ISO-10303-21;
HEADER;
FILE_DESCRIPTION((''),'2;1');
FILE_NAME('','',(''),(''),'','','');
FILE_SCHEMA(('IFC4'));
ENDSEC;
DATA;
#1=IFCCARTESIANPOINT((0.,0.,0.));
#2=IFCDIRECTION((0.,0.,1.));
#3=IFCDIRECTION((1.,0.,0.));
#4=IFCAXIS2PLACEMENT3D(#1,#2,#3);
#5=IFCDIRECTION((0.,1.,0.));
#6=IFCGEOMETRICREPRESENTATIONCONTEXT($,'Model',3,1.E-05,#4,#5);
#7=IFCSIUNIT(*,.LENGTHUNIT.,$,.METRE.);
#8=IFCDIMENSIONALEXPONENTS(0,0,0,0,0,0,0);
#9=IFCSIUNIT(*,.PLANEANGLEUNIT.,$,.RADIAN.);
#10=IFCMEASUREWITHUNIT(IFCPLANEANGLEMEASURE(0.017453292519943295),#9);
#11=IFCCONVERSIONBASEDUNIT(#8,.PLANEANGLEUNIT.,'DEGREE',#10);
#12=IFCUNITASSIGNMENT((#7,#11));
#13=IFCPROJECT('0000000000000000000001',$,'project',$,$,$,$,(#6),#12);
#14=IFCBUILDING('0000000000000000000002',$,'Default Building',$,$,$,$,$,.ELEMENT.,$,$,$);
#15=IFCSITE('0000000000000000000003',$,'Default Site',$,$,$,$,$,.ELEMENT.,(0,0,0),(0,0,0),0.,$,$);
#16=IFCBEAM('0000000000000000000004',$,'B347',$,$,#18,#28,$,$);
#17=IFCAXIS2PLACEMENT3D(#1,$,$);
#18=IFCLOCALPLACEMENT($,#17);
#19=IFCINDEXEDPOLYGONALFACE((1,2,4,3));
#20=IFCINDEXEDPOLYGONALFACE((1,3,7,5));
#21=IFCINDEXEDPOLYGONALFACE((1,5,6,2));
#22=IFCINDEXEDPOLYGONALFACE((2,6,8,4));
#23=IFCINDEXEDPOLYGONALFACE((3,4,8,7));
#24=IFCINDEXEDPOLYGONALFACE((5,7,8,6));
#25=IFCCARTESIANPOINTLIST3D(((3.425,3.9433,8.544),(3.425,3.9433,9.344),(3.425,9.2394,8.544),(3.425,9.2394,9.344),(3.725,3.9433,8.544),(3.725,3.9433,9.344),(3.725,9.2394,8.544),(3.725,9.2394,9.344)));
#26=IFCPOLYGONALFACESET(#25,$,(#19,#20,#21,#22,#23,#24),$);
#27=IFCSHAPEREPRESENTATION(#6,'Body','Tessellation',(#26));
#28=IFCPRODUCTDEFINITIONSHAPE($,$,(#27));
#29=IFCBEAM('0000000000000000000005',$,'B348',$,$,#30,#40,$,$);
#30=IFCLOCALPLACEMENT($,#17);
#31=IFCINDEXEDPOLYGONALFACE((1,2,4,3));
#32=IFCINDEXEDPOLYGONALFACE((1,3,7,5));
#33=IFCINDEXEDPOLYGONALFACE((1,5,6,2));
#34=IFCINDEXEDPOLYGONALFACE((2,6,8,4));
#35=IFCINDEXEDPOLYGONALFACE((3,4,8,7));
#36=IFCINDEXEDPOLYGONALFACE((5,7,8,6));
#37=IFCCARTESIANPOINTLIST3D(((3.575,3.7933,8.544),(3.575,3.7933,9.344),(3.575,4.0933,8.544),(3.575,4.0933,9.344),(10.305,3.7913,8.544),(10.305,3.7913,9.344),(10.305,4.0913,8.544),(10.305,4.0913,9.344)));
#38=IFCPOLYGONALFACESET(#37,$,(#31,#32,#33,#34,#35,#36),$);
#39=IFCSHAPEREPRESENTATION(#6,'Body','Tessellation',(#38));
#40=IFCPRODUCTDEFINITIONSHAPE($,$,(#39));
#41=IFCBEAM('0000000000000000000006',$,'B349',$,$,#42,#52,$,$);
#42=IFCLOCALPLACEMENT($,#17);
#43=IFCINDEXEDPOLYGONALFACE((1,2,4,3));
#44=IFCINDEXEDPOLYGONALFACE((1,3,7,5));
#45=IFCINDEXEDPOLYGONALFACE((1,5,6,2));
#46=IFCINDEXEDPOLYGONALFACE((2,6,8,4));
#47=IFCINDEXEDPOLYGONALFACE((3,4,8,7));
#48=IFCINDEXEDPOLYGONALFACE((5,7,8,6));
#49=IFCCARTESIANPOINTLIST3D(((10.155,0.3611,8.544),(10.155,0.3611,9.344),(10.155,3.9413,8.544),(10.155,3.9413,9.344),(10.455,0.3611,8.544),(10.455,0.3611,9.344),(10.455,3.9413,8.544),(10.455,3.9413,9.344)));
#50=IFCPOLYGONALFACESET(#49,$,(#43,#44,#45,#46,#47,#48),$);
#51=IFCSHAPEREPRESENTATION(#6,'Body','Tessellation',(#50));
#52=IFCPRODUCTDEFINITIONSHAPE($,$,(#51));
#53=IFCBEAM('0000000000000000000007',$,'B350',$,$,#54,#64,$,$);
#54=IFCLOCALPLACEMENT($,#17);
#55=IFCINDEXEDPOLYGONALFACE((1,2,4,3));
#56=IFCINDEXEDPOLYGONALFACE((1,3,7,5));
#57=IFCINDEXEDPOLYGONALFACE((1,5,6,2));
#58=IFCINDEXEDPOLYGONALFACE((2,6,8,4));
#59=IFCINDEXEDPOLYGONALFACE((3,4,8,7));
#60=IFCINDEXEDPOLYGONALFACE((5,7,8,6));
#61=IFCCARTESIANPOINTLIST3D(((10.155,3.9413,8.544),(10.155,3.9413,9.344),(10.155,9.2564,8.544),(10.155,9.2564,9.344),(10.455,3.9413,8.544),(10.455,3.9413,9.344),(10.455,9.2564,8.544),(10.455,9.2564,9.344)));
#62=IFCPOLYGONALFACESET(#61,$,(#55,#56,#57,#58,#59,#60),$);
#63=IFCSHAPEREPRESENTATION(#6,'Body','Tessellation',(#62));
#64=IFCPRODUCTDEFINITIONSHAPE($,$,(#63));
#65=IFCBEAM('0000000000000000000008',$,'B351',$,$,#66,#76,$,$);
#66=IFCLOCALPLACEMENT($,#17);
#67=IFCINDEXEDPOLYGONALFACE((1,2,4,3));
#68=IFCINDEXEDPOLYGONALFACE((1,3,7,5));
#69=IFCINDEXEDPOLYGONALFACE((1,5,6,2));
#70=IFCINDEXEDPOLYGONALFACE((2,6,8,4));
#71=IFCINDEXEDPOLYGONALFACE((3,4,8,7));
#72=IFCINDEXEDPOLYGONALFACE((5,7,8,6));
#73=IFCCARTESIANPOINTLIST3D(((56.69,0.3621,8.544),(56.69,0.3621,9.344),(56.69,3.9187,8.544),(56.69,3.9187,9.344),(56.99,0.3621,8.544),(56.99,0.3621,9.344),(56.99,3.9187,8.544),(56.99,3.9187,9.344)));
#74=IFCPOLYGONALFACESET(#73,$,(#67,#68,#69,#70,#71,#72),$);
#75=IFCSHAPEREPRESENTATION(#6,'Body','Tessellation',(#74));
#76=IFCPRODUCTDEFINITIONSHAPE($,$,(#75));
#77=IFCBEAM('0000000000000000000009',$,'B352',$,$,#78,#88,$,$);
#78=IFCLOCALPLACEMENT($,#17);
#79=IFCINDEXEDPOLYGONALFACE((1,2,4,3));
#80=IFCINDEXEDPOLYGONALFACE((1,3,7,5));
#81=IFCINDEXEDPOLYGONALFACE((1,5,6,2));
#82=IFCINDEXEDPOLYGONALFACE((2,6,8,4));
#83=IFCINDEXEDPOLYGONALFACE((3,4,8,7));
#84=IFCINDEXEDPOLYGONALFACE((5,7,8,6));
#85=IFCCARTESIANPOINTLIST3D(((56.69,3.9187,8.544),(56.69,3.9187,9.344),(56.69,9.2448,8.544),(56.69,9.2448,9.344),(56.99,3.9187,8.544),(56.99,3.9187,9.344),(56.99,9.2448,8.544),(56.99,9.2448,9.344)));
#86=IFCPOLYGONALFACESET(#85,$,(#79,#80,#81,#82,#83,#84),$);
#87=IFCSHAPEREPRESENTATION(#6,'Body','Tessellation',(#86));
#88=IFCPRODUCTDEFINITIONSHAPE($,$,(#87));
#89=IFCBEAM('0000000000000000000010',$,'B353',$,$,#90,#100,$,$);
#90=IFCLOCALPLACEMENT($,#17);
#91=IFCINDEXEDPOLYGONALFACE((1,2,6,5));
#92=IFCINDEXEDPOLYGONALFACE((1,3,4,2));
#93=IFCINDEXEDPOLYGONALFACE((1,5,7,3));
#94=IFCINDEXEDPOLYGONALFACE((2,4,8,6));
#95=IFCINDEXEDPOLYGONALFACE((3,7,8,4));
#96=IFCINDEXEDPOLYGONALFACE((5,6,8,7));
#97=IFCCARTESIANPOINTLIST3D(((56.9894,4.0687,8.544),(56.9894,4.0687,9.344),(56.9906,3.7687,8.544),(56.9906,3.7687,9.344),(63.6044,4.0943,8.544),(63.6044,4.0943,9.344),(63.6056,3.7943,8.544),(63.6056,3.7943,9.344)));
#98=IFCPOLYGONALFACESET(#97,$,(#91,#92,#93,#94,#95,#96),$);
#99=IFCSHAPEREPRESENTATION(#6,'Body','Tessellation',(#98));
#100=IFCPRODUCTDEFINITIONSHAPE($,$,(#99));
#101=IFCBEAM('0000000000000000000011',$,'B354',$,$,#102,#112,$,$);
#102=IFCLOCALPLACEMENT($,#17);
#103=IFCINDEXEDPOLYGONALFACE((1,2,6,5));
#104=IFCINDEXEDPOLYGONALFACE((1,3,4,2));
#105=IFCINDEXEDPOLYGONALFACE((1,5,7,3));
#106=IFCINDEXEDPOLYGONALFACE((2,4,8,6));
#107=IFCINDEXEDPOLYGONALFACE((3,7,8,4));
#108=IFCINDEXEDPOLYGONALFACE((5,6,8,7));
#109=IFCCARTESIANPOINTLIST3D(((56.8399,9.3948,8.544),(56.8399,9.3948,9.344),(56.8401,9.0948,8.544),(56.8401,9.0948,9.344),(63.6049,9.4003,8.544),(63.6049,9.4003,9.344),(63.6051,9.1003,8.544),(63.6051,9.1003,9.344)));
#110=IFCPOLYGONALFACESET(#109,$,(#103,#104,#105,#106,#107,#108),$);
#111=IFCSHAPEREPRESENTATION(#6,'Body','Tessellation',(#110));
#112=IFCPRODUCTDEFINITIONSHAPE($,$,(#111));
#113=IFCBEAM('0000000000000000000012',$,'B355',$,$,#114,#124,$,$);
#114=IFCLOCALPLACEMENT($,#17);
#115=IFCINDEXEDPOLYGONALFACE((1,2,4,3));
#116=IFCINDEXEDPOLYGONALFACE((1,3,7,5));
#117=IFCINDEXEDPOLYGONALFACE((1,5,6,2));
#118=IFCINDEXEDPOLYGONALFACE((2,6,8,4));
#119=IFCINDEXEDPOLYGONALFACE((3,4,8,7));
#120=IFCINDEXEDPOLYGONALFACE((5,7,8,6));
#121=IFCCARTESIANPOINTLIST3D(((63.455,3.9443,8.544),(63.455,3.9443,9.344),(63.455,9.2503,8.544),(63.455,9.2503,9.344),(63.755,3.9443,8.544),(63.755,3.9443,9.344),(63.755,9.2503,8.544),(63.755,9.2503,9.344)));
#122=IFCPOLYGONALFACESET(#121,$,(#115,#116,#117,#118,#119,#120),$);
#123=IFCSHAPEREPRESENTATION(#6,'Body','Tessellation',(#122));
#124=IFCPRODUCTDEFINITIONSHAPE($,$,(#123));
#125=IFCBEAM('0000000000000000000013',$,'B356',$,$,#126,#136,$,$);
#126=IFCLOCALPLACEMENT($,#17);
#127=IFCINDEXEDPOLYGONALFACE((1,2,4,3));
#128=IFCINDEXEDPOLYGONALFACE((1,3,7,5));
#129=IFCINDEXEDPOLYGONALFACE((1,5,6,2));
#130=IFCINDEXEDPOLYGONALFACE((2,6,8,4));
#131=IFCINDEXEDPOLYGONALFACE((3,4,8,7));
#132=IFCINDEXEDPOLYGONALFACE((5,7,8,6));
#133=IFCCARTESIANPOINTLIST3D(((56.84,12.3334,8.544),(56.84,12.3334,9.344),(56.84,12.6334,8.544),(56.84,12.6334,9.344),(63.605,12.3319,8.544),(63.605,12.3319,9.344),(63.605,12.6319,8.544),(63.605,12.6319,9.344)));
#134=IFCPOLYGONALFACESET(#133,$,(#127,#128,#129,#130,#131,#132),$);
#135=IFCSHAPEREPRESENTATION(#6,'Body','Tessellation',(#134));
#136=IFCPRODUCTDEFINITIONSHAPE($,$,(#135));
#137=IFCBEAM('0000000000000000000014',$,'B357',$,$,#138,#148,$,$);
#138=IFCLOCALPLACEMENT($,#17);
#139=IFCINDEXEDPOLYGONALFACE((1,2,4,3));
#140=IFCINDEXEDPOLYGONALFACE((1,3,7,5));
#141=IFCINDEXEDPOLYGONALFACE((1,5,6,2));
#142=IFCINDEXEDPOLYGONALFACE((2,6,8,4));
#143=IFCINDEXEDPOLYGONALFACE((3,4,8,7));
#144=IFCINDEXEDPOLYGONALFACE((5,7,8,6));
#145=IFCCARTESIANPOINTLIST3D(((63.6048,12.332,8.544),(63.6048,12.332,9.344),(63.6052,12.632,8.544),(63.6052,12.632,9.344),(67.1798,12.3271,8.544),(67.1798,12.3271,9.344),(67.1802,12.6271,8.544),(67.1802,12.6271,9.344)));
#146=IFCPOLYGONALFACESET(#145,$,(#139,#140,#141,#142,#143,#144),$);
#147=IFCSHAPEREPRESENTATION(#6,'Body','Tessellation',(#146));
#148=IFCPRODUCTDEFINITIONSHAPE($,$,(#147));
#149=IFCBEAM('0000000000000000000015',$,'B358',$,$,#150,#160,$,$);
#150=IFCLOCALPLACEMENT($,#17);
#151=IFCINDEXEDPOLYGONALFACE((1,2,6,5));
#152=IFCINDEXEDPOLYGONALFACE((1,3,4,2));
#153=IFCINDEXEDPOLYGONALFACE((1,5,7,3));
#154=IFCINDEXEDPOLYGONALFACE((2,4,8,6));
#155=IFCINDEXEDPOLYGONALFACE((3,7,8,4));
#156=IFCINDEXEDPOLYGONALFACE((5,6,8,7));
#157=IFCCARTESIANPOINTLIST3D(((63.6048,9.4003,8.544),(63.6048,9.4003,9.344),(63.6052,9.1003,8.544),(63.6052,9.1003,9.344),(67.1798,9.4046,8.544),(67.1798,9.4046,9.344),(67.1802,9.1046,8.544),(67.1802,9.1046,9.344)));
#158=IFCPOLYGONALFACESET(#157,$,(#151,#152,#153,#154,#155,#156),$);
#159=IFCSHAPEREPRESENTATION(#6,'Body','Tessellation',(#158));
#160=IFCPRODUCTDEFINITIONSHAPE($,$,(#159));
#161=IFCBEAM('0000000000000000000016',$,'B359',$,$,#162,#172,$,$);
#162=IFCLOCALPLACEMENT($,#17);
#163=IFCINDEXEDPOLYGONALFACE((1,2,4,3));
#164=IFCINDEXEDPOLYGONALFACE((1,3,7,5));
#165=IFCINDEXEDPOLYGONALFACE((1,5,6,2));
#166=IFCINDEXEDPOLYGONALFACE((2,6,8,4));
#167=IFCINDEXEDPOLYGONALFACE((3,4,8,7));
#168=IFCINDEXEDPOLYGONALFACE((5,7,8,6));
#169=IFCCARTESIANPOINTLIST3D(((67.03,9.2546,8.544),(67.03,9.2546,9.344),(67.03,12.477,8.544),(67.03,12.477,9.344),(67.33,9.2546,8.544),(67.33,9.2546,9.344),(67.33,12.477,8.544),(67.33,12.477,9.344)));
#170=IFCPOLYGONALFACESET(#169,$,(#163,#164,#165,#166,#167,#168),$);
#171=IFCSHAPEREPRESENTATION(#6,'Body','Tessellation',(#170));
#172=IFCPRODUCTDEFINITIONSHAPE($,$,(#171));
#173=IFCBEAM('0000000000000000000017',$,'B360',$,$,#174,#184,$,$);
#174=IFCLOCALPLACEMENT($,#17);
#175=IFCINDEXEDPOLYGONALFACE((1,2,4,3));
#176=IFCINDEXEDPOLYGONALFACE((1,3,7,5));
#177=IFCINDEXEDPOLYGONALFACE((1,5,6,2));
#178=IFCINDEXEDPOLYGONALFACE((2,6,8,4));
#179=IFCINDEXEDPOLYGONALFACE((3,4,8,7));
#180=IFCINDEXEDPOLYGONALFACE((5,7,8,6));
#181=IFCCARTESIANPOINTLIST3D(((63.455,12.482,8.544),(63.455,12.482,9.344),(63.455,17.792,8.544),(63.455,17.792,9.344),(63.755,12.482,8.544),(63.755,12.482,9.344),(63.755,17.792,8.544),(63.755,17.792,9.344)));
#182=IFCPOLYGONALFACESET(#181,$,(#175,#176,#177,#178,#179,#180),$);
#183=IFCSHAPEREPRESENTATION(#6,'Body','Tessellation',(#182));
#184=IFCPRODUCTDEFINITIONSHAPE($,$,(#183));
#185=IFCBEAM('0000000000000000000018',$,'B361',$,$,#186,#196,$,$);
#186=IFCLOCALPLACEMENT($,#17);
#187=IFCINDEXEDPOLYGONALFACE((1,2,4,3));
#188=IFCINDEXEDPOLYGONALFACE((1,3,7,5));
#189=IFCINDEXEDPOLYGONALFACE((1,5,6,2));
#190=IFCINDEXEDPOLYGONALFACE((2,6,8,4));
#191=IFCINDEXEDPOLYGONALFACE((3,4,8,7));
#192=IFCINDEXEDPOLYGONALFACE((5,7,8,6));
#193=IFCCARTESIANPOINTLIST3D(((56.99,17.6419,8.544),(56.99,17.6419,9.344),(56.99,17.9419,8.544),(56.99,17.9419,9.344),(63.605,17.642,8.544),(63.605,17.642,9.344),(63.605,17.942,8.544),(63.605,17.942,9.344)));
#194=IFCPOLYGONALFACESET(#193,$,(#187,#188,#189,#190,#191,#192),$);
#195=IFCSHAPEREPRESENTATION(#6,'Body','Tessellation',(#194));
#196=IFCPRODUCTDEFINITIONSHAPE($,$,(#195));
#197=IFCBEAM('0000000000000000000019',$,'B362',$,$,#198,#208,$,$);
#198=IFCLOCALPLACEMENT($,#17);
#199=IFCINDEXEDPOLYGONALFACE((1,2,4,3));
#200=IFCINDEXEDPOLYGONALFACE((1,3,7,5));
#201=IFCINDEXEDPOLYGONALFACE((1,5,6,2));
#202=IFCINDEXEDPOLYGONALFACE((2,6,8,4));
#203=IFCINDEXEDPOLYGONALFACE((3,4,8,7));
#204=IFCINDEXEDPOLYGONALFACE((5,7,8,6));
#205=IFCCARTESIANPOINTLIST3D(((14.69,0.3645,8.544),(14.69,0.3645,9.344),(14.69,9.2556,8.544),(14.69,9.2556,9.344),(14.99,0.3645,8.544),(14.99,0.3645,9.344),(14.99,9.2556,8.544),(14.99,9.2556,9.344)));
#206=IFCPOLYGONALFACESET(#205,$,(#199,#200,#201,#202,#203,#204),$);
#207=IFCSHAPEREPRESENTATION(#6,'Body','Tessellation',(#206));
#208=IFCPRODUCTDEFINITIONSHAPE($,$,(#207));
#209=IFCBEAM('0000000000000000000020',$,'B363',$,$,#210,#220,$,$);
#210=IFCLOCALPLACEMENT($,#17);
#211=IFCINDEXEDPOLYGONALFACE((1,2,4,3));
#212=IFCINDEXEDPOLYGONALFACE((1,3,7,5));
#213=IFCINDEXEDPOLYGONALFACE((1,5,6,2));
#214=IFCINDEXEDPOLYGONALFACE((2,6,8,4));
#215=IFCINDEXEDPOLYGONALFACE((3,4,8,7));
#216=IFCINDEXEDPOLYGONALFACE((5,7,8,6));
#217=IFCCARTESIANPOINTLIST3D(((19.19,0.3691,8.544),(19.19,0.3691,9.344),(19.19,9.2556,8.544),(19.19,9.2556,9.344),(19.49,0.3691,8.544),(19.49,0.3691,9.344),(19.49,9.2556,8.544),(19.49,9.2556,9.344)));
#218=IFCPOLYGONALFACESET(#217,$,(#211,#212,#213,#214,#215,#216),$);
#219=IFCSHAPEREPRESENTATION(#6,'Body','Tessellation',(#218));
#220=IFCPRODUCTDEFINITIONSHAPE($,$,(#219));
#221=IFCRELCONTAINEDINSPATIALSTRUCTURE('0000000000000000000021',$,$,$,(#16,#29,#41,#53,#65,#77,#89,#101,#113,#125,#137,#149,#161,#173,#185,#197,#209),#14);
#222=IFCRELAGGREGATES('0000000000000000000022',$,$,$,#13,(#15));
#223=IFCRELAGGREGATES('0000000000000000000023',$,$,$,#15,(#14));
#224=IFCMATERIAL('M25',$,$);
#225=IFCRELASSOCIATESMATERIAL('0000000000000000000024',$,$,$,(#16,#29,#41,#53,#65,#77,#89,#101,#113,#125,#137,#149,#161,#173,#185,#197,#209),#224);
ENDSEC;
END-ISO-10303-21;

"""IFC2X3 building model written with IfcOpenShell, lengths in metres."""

from ifc_helpers import new_model, entity, si_unit, converted_unit, direction, frame, frame_2d, origin_with_axes, place, context, project, spatial, rectangle, extrude, material, element, save


model = new_model("IFC2X3")

# Units and contexts
model_context = context("Model", 3, precision=1e-05, world=origin_with_axes(), true_north=direction((0.0, 1.0, 0.0)))
ifc_project = project(units=[si_unit("LENGTHUNIT", "METRE"), converted_unit("PLANEANGLEUNIT", "DEGREE", entity("IfcPlaneAngleMeasure", 0.017453292519943295), si_unit("PLANEANGLEUNIT", "RADIAN"), dimensions=[0, 0, 0, 0, 0, 0, 0])], contexts=[model_context])

# Site, building
site = spatial("IfcSite", under=ifc_project, Name="Default Site", CompositionType="ELEMENT", RefLatitude=(0, 0, 0), RefLongitude=(0, 0, 0), RefElevation=0.0)
building = spatial("IfcBuilding", under=site, Name="Default Building", CompositionType="ELEMENT")

# Beams
ifc_material = material(Name="M25")
placement = place(None, origin_with_axes())
element("IfcBeam", 1, at=placement, inside=building, material=ifc_material, Name="B347", context=model_context, shape_type="SweptSolid", body=[
    extrude(rectangle(XDim=0.3, YDim=0.8, at=frame_2d((0.0, 0.0), x_axis=(0.0, 1.0, 0.0))), frame((3.575, 3.9433, 8.944), z_axis=(0.0, 1.0, 0.0), x_axis=(0.0, 0.0, -1.0)), (0.0, 0.0, 1.0), 5.2961),
])
element("IfcBeam", 2, at=placement, inside=building, material=ifc_material, Name="B348", context=model_context, shape_type="SweptSolid", body=[
    extrude(rectangle(XDim=0.3, YDim=0.8, at=frame_2d((0.0, 0.0), x_axis=(0.0, 1.0, 0.0))), frame((3.575, 3.9433, 8.944), z_axis=(1.0, -0.000302, 0.0), x_axis=(0.0, 0.0, -1.0)), (0.0, 0.0, 1.0), 6.73),
])
element("IfcBeam", 3, at=placement, inside=building, material=ifc_material, Name="B349", context=model_context, shape_type="SweptSolid", body=[
    extrude(rectangle(XDim=0.3, YDim=0.8, at=frame_2d((0.0, 0.0), x_axis=(0.0, 1.0, 0.0))), frame((10.305, 3.9413, 8.944), z_axis=(0.0, -1.0, 0.0), x_axis=(0.0, 0.0, -1.0)), (0.0, 0.0, 1.0), 3.5802),
])
element("IfcBeam", 4, at=placement, inside=building, material=ifc_material, Name="B350", context=model_context, shape_type="SweptSolid", body=[
    extrude(rectangle(XDim=0.3, YDim=0.8, at=frame_2d((0.0, 0.0), x_axis=(0.0, 1.0, 0.0))), frame((10.305, 3.9413, 8.944), z_axis=(0.0, 1.0, 0.0), x_axis=(0.0, 0.0, -1.0)), (0.0, 0.0, 1.0), 5.3151),
])
element("IfcBeam", 5, at=placement, inside=building, material=ifc_material, Name="B351", context=model_context, shape_type="SweptSolid", body=[
    extrude(rectangle(XDim=0.3, YDim=0.8, at=frame_2d((0.0, 0.0), x_axis=(0.0, 1.0, 0.0))), frame((56.84, 0.3621, 8.944), z_axis=(0.0, 1.0, 0.0), x_axis=(0.0, 0.0, -1.0)), (0.0, 0.0, 1.0), 3.5566),
])
element("IfcBeam", 6, at=placement, inside=building, material=ifc_material, Name="B352", context=model_context, shape_type="SweptSolid", body=[
    extrude(rectangle(XDim=0.3, YDim=0.8, at=frame_2d((0.0, 0.0), x_axis=(0.0, 1.0, 0.0))), frame((56.84, 3.9187, 8.944), z_axis=(0.0, 1.0, 0.0), x_axis=(0.0, 0.0, -1.0)), (0.0, 0.0, 1.0), 5.3261),
])
element("IfcBeam", 7, at=placement, inside=building, material=ifc_material, Name="B353", context=model_context, shape_type="SweptSolid", body=[
    extrude(rectangle(XDim=0.3, YDim=0.8, at=frame_2d((0.0, 0.0), x_axis=(0.0, 1.0, 0.0))), frame((56.99, 3.9187, 8.944), z_axis=(0.999993, 0.003873, 0.0), x_axis=(0.0, 0.0, -1.0)), (0.0, 0.0, 1.0), 6.6151),
])
element("IfcBeam", 8, at=placement, inside=building, material=ifc_material, Name="B354", context=model_context, shape_type="SweptSolid", body=[
    extrude(rectangle(XDim=0.3, YDim=0.8, at=frame_2d((0.0, 0.0), x_axis=(0.0, 1.0, 0.0))), frame((56.84, 9.2448, 8.944), z_axis=(1.0, 0.000816, 0.0), x_axis=(0.0, 0.0, -1.0)), (0.0, 0.0, 1.0), 6.765),
])
element("IfcBeam", 9, at=placement, inside=building, material=ifc_material, Name="B355", context=model_context, shape_type="SweptSolid", body=[
    extrude(rectangle(XDim=0.3, YDim=0.8, at=frame_2d((0.0, 0.0), x_axis=(0.0, 1.0, 0.0))), frame((63.605, 3.9443, 8.944), z_axis=(0.0, 1.0, 0.0), x_axis=(0.0, 0.0, -1.0)), (0.0, 0.0, 1.0), 5.306),
])
element("IfcBeam", 10, at=placement, inside=building, material=ifc_material, Name="B356", context=model_context, shape_type="SweptSolid", body=[
    extrude(rectangle(XDim=0.3, YDim=0.8, at=frame_2d((0.0, 0.0), x_axis=(0.0, 1.0, 0.0))), frame((56.84, 12.4834, 8.944), z_axis=(1.0, -0.000216, 0.0), x_axis=(0.0, 0.0, -1.0)), (0.0, 0.0, 1.0), 6.765),
])
element("IfcBeam", 11, at=placement, inside=building, material=ifc_material, Name="B357", context=model_context, shape_type="SweptSolid", body=[
    extrude(rectangle(XDim=0.3, YDim=0.8, at=frame_2d((0.0, 0.0), x_axis=(0.0, 1.0, 0.0))), frame((63.605, 12.482, 8.944), z_axis=(0.999999, -0.001379, 0.0), x_axis=(0.0, 0.0, -1.0)), (0.0, 0.0, 1.0), 3.575),
])
element("IfcBeam", 12, at=placement, inside=building, material=ifc_material, Name="B358", context=model_context, shape_type="SweptSolid", body=[
    extrude(rectangle(XDim=0.3, YDim=0.8, at=frame_2d((0.0, 0.0), x_axis=(0.0, 1.0, 0.0))), frame((63.605, 9.2503, 8.944), z_axis=(0.999999, 0.001188, 0.0), x_axis=(0.0, 0.0, -1.0)), (0.0, 0.0, 1.0), 3.575),
])
element("IfcBeam", 13, at=placement, inside=building, material=ifc_material, Name="B359", context=model_context, shape_type="SweptSolid", body=[
    extrude(rectangle(XDim=0.3, YDim=0.8, at=frame_2d((0.0, 0.0), x_axis=(0.0, 1.0, 0.0))), frame((67.18, 9.2546, 8.944), z_axis=(0.0, 1.0, 0.0), x_axis=(0.0, 0.0, -1.0)), (0.0, 0.0, 1.0), 3.2224),
])
element("IfcBeam", 14, at=placement, inside=building, material=ifc_material, Name="B360", context=model_context, shape_type="SweptSolid", body=[
    extrude(rectangle(XDim=0.3, YDim=0.8, at=frame_2d((0.0, 0.0), x_axis=(0.0, 1.0, 0.0))), frame((63.605, 12.482, 8.944), z_axis=(0.0, 1.0, 0.0), x_axis=(0.0, 0.0, -1.0)), (0.0, 0.0, 1.0), 5.3101),
])
element("IfcBeam", 15, at=placement, inside=building, material=ifc_material, Name="B361", context=model_context, shape_type="SweptSolid", body=[
    extrude(rectangle(XDim=0.3, YDim=0.8, at=frame_2d((0.0, 0.0), x_axis=(0.0, 1.0, 0.0))), frame((56.99, 17.7919, 8.944), z_axis=(1.0, 0.00002, 0.0), x_axis=(0.0, 0.0, -1.0)), (0.0, 0.0, 1.0), 6.615),
])
element("IfcBeam", 16, at=placement, inside=building, material=ifc_material, Name="B362", context=model_context, shape_type="SweptSolid", body=[
    extrude(rectangle(XDim=0.3, YDim=0.8, at=frame_2d((0.0, 0.0), x_axis=(0.0, 1.0, 0.0))), frame((14.84, 0.3645, 8.944), z_axis=(0.0, 1.0, 0.0), x_axis=(0.0, 0.0, -1.0)), (0.0, 0.0, 1.0), 8.891),
])
element("IfcBeam", 17, at=placement, inside=building, material=ifc_material, Name="B363", context=model_context, shape_type="SweptSolid", body=[
    extrude(rectangle(XDim=0.3, YDim=0.8, at=frame_2d((0.0, 0.0), x_axis=(0.0, 1.0, 0.0))), frame((19.34, 0.3691, 8.944), z_axis=(0.0, 1.0, 0.0), x_axis=(0.0, 0.0, -1.0)), (0.0, 0.0, 1.0), 8.8865),
])

save(model, "model.ifc")
